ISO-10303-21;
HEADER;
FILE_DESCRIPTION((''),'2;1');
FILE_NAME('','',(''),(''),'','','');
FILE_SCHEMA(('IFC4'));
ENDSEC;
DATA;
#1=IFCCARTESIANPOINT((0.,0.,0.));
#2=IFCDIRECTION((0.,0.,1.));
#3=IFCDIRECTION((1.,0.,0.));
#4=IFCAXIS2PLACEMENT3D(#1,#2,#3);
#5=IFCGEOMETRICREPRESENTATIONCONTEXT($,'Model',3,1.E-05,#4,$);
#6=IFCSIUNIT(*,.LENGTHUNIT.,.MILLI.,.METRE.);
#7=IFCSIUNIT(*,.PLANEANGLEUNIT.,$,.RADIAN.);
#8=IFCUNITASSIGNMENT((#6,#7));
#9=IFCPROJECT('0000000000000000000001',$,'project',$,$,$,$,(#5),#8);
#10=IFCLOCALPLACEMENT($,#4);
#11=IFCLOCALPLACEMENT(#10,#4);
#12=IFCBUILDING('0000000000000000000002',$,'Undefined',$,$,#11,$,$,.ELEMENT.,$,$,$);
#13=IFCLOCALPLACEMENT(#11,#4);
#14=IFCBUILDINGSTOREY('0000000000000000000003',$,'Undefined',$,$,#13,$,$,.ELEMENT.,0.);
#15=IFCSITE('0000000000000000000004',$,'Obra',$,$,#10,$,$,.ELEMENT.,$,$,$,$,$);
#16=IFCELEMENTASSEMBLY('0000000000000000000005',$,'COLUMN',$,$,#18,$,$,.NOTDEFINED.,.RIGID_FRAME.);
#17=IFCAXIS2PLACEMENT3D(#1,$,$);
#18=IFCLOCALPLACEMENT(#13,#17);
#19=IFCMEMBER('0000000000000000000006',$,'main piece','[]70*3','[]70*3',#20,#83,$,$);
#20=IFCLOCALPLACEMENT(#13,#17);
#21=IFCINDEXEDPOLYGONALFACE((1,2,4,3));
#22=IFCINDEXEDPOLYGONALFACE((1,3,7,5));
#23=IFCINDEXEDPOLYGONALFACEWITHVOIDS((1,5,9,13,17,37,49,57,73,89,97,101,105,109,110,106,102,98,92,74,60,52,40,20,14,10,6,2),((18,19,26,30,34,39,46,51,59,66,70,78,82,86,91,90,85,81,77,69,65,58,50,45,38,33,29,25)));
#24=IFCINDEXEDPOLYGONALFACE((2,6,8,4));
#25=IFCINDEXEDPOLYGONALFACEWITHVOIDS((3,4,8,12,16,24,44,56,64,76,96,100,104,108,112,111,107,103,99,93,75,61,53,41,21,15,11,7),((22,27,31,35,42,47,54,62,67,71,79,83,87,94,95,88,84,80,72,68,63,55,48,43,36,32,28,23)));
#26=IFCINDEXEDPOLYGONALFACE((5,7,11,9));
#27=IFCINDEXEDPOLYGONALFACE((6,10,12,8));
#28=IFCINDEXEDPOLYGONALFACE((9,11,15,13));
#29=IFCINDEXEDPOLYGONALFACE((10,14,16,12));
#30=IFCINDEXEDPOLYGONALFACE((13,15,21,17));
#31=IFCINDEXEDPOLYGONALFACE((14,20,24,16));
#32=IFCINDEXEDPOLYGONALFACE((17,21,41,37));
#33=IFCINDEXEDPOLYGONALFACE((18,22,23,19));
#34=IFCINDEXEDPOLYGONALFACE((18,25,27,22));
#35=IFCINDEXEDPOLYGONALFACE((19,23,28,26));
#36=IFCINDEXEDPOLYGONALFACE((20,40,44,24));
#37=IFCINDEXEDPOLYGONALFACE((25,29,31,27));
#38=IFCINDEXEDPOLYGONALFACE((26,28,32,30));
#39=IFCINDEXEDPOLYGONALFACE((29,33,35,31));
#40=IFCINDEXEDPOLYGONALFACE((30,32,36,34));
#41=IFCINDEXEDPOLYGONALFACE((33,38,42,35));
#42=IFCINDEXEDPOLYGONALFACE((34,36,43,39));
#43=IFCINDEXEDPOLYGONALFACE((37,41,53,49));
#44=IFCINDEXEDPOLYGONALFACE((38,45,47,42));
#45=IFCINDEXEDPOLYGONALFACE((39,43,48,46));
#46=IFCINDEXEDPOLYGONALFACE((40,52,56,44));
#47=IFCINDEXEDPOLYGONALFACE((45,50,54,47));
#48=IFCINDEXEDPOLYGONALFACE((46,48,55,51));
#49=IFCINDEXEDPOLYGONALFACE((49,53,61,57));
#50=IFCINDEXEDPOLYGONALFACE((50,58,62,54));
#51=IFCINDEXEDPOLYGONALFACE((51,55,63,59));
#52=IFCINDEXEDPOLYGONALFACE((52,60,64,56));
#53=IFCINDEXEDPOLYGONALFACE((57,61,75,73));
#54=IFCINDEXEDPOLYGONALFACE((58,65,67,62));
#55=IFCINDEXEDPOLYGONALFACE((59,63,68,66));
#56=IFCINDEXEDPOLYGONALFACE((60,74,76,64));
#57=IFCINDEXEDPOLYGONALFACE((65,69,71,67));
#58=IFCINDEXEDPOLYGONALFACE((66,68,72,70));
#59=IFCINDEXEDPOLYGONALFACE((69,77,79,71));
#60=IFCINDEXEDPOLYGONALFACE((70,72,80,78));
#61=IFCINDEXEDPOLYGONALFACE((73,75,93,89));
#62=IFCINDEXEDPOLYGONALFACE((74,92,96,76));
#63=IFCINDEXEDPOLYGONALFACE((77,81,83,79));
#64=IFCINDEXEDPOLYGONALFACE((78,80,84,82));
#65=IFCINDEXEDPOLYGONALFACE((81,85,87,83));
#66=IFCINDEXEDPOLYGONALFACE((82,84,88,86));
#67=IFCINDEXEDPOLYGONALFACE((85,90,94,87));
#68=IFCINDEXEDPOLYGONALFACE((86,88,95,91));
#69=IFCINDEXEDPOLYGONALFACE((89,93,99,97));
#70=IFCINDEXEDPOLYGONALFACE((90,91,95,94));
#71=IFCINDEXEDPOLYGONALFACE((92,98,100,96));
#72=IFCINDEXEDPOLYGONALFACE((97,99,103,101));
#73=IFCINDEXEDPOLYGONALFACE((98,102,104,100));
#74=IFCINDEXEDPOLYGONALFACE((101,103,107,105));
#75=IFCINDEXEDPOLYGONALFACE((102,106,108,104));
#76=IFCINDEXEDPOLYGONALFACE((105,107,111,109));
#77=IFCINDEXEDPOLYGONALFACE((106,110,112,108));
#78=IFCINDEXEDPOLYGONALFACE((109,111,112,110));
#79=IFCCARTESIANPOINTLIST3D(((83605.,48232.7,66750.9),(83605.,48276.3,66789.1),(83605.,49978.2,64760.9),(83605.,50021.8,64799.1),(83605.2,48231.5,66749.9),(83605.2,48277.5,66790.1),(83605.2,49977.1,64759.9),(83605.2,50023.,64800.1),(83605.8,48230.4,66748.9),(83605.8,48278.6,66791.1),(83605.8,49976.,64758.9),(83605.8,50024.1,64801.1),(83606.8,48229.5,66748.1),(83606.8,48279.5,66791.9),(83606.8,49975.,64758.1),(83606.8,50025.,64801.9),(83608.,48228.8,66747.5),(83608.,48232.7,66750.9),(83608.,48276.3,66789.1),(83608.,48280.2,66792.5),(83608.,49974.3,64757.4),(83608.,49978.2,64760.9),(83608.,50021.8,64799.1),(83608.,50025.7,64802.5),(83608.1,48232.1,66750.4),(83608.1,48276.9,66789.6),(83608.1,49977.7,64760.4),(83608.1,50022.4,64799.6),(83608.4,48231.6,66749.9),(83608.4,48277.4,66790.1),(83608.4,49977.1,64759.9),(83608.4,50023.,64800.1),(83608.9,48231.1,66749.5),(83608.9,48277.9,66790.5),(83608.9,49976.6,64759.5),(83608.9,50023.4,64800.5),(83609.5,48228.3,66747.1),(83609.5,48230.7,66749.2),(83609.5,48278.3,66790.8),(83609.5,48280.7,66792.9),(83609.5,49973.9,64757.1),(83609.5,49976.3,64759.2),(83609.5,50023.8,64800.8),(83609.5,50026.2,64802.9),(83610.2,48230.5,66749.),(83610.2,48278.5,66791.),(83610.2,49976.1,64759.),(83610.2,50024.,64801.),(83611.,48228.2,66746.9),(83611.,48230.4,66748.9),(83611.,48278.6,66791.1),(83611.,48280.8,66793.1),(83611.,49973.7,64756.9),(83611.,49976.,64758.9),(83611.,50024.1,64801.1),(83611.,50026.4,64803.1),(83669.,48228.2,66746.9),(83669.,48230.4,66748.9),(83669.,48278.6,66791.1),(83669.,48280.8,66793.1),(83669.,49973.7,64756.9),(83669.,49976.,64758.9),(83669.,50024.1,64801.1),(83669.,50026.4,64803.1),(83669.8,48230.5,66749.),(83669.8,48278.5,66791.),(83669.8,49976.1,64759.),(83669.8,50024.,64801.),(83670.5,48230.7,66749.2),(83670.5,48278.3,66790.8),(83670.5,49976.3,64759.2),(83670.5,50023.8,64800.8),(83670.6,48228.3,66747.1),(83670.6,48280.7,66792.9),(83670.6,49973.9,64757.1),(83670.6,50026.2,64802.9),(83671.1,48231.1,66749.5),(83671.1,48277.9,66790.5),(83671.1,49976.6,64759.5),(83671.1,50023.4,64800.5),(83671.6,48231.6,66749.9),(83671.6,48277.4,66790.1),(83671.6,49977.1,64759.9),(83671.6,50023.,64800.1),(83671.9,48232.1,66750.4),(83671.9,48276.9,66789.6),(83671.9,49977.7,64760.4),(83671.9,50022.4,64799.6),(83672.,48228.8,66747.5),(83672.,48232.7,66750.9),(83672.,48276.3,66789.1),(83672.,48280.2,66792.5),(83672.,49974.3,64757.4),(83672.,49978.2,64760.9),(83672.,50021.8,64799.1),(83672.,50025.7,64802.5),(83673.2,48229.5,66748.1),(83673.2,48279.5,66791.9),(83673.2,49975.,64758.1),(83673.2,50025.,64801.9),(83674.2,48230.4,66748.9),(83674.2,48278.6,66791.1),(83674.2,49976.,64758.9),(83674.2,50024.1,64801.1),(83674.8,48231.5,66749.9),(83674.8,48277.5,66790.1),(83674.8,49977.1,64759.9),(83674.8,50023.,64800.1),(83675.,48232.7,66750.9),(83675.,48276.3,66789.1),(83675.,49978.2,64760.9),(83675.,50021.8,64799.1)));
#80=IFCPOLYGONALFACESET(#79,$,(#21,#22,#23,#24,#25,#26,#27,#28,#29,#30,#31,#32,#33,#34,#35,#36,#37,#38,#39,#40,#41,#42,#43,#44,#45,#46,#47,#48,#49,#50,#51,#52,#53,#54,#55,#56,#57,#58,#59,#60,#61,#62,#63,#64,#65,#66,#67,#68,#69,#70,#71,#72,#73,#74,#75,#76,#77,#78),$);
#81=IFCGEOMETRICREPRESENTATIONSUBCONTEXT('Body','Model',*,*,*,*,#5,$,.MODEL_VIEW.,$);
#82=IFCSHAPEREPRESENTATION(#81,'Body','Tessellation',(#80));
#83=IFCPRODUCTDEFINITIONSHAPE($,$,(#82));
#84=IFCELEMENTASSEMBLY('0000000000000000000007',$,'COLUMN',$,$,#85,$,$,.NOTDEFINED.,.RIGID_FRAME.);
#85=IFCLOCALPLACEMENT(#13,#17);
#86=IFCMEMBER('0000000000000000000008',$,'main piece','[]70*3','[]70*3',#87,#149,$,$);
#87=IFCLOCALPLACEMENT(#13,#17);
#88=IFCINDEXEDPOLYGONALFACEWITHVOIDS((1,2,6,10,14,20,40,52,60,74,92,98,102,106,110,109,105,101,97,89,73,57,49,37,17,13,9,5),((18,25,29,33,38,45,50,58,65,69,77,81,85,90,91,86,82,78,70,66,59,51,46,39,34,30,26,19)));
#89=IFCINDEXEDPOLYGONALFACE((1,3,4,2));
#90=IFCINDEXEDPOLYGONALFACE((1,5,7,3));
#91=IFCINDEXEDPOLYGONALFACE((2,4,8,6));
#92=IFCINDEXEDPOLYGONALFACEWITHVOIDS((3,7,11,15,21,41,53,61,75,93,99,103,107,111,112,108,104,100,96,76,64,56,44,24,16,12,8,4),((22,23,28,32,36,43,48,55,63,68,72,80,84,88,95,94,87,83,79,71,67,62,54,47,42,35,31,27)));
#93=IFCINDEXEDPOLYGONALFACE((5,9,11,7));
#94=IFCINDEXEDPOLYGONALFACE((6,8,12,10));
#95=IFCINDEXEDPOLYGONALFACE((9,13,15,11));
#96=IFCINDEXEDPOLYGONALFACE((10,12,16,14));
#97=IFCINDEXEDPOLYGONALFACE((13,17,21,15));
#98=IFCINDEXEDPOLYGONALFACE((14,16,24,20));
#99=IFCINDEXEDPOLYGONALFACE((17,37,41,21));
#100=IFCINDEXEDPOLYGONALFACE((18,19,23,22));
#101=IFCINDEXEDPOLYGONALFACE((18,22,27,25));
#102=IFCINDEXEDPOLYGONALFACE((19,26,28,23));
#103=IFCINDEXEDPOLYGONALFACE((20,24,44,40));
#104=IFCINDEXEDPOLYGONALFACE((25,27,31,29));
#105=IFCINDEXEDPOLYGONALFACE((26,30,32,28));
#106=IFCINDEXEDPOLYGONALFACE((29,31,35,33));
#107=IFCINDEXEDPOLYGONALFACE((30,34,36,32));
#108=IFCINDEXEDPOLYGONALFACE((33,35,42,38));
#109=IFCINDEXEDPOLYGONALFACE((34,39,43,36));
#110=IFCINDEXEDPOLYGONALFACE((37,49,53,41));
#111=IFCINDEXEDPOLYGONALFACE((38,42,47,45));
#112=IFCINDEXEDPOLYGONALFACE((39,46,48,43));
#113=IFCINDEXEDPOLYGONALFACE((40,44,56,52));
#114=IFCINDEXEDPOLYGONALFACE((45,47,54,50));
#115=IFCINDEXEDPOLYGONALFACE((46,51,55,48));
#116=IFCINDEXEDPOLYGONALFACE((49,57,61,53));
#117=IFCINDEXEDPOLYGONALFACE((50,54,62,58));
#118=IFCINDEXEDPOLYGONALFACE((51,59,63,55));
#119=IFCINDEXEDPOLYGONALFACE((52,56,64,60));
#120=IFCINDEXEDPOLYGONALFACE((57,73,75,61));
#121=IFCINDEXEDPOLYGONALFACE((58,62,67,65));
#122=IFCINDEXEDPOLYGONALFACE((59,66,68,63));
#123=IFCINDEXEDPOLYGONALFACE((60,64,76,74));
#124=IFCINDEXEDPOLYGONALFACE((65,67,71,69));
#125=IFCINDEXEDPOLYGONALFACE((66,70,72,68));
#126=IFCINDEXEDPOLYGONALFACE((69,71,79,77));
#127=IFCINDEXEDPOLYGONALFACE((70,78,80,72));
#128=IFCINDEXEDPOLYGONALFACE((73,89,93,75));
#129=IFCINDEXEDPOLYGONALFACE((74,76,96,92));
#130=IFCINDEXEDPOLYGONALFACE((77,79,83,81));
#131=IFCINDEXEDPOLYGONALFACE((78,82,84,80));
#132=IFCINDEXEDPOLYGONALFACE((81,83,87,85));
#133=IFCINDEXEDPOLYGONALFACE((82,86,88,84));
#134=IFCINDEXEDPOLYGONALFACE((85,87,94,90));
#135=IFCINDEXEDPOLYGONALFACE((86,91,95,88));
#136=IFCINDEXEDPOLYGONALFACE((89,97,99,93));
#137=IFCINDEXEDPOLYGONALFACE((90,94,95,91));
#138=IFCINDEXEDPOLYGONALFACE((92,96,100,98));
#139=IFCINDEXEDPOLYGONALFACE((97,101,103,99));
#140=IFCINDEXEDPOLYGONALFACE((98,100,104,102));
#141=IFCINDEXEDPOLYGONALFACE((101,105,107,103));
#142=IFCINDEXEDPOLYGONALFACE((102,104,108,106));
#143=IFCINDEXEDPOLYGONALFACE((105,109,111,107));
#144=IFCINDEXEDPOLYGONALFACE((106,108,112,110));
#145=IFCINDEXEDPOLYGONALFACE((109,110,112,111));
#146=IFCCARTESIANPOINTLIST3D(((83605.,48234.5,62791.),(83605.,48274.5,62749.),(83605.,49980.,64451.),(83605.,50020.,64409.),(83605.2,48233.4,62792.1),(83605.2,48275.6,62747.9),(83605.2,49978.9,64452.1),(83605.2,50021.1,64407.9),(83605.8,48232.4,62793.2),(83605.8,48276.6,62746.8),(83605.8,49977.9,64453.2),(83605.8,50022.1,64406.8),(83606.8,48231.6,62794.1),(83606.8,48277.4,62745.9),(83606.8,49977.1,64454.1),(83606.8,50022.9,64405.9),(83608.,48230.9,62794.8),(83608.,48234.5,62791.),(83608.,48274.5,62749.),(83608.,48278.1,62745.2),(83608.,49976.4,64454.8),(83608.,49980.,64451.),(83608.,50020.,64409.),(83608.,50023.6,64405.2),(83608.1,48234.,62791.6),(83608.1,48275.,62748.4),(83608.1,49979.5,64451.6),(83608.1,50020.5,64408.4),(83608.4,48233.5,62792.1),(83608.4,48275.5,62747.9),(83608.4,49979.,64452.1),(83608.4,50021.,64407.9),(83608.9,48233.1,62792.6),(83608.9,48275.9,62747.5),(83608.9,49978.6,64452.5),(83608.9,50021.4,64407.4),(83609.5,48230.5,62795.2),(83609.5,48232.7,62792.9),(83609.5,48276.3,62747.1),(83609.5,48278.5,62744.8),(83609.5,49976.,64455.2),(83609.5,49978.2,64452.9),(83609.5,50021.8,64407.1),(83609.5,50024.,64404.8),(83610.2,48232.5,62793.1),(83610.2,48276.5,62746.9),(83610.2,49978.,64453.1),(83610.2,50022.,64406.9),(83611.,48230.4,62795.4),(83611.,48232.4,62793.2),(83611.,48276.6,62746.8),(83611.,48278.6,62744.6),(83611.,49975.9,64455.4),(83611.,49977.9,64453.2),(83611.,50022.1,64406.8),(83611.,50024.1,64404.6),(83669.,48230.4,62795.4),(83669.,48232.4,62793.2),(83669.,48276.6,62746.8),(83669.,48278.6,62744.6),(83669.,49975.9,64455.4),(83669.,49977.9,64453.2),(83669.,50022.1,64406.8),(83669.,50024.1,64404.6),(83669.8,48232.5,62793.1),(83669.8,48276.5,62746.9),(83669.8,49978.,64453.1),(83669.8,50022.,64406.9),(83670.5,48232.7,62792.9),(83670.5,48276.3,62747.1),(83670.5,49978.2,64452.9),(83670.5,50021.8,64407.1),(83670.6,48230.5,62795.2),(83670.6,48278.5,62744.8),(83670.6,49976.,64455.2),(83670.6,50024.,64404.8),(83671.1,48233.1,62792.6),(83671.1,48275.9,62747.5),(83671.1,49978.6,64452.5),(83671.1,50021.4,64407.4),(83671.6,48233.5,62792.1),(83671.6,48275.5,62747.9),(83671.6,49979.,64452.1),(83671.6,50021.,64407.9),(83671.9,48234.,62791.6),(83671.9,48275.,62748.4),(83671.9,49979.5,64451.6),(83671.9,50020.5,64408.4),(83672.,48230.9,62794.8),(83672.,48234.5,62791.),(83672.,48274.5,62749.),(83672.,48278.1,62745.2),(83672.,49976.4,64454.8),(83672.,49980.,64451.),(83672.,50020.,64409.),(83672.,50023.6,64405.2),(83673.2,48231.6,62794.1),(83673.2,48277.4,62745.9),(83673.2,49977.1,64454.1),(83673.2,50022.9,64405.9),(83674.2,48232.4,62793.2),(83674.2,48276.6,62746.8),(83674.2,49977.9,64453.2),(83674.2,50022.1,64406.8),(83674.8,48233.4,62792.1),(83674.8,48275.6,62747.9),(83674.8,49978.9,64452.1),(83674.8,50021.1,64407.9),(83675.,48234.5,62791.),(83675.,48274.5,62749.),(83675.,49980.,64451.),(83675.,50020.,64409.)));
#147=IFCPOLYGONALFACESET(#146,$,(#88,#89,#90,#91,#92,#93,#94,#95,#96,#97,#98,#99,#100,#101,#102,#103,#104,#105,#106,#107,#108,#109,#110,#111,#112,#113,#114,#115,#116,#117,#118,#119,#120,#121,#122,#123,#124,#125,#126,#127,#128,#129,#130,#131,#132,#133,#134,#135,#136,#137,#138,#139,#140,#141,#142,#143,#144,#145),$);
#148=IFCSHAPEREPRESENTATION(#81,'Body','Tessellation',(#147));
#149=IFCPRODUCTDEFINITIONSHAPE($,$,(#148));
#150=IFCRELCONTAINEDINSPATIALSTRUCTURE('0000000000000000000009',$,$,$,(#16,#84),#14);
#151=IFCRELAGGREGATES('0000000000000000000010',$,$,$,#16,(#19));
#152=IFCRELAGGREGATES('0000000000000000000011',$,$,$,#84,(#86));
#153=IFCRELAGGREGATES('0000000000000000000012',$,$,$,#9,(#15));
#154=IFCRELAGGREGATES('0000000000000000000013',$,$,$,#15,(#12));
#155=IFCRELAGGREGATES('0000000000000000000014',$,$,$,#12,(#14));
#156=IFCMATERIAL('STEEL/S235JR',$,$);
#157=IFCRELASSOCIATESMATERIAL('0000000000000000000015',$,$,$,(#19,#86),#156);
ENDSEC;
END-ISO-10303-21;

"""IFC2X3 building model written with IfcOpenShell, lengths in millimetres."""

from ifc_helpers import new_model, si_unit, frame, origin_with_axes, origin_2d_with_axis, place, context, subcontext, project, spatial, hollow_rectangle, extrude, material, element, aggregate, save


model = new_model("IFC2X3")

# Units and contexts
model_context = context("Model", 3, precision=1e-05, world=origin_with_axes())
body_context = subcontext(model_context, "Body", "Model", "MODEL_VIEW")
ifc_project = project(units=[si_unit("LENGTHUNIT", "METRE", prefix="MILLI"), si_unit("PLANEANGLEUNIT", "RADIAN")], contexts=[model_context])

# Site, building, storey
site_placement = place(None, origin_with_axes())
site = spatial("IfcSite", under=ifc_project, at=site_placement, Name="Obra", CompositionType="ELEMENT")
building_placement = place(site_placement, origin_with_axes())
building = spatial("IfcBuilding", under=site, at=building_placement, Name="Undefined", CompositionType="ELEMENT")
storey_placement = place(building_placement, origin_with_axes())
storey = spatial("IfcBuildingStorey", under=building, at=storey_placement, Name="Undefined", CompositionType="ELEMENT", Elevation=0.0)

# Shared definitions
ifc_material = material(Name="STEEL/S235JR")

# Element assemblies, members
assembly_1_placement = place(storey_placement, origin_with_axes())
assembly_1 = element("IfcElementAssembly", 1, at=assembly_1_placement, inside=storey, Name="COLUMN", AssemblyPlace="NOTDEFINED", PredefinedType="RIGID_FRAME")
member_1_placement = place(assembly_1_placement, frame((83640.0, 50000.0, 64780.0), z_axis=(1.0, 0.0, 0.0), x_axis=(0.0, -0.659423, 0.751772)))
member_1 = element("IfcMember", 2, at=member_1_placement, material=ifc_material, Name="main piece", Description="[]70*3", ObjectType="[]70*3", context=body_context, shape_type="SweptSolid", body=[
    extrude(hollow_rectangle(XDim=70.0, YDim=70.0, WallThickness=3.0, InnerFilletRadius=3.0, OuterFilletRadius=6.0, at=origin_2d_with_axis()), frame((2647.1, 0.0, 0.0), z_axis=(-1.0, 0.0, 0.0), x_axis=(0.0, -1.0, 0.0)), (0.0, 0.0, 1.0), 2647.1),
])
aggregate(assembly_1, [member_1])
assembly_2_placement = place(storey_placement, origin_with_axes())
assembly_2 = element("IfcElementAssembly", 3, at=assembly_2_placement, inside=storey, Name="COLUMN", AssemblyPlace="NOTDEFINED", PredefinedType="RIGID_FRAME")
member_2_placement = place(assembly_2_placement, frame((83640.0, 48254.5, 62770.0), z_axis=(-1.0, 0.0, 0.0), x_axis=(0.0, 0.724633, 0.689135)))
member_2 = element("IfcMember", 4, at=member_2_placement, material=ifc_material, Name="main piece", Description="[]70*3", ObjectType="[]70*3", context=body_context, shape_type="SweptSolid", body=[
    extrude(hollow_rectangle(XDim=70.0, YDim=70.0, WallThickness=3.0, InnerFilletRadius=3.0, OuterFilletRadius=6.0, at=origin_2d_with_axis()), frame((2408.8, 0.0, 0.0), z_axis=(-1.0, 0.0, 0.0), x_axis=(0.0, -1.0, 0.0)), (0.0, 0.0, 1.0), 2408.8),
])
aggregate(assembly_2, [member_2])

save(model, "model.ifc")
